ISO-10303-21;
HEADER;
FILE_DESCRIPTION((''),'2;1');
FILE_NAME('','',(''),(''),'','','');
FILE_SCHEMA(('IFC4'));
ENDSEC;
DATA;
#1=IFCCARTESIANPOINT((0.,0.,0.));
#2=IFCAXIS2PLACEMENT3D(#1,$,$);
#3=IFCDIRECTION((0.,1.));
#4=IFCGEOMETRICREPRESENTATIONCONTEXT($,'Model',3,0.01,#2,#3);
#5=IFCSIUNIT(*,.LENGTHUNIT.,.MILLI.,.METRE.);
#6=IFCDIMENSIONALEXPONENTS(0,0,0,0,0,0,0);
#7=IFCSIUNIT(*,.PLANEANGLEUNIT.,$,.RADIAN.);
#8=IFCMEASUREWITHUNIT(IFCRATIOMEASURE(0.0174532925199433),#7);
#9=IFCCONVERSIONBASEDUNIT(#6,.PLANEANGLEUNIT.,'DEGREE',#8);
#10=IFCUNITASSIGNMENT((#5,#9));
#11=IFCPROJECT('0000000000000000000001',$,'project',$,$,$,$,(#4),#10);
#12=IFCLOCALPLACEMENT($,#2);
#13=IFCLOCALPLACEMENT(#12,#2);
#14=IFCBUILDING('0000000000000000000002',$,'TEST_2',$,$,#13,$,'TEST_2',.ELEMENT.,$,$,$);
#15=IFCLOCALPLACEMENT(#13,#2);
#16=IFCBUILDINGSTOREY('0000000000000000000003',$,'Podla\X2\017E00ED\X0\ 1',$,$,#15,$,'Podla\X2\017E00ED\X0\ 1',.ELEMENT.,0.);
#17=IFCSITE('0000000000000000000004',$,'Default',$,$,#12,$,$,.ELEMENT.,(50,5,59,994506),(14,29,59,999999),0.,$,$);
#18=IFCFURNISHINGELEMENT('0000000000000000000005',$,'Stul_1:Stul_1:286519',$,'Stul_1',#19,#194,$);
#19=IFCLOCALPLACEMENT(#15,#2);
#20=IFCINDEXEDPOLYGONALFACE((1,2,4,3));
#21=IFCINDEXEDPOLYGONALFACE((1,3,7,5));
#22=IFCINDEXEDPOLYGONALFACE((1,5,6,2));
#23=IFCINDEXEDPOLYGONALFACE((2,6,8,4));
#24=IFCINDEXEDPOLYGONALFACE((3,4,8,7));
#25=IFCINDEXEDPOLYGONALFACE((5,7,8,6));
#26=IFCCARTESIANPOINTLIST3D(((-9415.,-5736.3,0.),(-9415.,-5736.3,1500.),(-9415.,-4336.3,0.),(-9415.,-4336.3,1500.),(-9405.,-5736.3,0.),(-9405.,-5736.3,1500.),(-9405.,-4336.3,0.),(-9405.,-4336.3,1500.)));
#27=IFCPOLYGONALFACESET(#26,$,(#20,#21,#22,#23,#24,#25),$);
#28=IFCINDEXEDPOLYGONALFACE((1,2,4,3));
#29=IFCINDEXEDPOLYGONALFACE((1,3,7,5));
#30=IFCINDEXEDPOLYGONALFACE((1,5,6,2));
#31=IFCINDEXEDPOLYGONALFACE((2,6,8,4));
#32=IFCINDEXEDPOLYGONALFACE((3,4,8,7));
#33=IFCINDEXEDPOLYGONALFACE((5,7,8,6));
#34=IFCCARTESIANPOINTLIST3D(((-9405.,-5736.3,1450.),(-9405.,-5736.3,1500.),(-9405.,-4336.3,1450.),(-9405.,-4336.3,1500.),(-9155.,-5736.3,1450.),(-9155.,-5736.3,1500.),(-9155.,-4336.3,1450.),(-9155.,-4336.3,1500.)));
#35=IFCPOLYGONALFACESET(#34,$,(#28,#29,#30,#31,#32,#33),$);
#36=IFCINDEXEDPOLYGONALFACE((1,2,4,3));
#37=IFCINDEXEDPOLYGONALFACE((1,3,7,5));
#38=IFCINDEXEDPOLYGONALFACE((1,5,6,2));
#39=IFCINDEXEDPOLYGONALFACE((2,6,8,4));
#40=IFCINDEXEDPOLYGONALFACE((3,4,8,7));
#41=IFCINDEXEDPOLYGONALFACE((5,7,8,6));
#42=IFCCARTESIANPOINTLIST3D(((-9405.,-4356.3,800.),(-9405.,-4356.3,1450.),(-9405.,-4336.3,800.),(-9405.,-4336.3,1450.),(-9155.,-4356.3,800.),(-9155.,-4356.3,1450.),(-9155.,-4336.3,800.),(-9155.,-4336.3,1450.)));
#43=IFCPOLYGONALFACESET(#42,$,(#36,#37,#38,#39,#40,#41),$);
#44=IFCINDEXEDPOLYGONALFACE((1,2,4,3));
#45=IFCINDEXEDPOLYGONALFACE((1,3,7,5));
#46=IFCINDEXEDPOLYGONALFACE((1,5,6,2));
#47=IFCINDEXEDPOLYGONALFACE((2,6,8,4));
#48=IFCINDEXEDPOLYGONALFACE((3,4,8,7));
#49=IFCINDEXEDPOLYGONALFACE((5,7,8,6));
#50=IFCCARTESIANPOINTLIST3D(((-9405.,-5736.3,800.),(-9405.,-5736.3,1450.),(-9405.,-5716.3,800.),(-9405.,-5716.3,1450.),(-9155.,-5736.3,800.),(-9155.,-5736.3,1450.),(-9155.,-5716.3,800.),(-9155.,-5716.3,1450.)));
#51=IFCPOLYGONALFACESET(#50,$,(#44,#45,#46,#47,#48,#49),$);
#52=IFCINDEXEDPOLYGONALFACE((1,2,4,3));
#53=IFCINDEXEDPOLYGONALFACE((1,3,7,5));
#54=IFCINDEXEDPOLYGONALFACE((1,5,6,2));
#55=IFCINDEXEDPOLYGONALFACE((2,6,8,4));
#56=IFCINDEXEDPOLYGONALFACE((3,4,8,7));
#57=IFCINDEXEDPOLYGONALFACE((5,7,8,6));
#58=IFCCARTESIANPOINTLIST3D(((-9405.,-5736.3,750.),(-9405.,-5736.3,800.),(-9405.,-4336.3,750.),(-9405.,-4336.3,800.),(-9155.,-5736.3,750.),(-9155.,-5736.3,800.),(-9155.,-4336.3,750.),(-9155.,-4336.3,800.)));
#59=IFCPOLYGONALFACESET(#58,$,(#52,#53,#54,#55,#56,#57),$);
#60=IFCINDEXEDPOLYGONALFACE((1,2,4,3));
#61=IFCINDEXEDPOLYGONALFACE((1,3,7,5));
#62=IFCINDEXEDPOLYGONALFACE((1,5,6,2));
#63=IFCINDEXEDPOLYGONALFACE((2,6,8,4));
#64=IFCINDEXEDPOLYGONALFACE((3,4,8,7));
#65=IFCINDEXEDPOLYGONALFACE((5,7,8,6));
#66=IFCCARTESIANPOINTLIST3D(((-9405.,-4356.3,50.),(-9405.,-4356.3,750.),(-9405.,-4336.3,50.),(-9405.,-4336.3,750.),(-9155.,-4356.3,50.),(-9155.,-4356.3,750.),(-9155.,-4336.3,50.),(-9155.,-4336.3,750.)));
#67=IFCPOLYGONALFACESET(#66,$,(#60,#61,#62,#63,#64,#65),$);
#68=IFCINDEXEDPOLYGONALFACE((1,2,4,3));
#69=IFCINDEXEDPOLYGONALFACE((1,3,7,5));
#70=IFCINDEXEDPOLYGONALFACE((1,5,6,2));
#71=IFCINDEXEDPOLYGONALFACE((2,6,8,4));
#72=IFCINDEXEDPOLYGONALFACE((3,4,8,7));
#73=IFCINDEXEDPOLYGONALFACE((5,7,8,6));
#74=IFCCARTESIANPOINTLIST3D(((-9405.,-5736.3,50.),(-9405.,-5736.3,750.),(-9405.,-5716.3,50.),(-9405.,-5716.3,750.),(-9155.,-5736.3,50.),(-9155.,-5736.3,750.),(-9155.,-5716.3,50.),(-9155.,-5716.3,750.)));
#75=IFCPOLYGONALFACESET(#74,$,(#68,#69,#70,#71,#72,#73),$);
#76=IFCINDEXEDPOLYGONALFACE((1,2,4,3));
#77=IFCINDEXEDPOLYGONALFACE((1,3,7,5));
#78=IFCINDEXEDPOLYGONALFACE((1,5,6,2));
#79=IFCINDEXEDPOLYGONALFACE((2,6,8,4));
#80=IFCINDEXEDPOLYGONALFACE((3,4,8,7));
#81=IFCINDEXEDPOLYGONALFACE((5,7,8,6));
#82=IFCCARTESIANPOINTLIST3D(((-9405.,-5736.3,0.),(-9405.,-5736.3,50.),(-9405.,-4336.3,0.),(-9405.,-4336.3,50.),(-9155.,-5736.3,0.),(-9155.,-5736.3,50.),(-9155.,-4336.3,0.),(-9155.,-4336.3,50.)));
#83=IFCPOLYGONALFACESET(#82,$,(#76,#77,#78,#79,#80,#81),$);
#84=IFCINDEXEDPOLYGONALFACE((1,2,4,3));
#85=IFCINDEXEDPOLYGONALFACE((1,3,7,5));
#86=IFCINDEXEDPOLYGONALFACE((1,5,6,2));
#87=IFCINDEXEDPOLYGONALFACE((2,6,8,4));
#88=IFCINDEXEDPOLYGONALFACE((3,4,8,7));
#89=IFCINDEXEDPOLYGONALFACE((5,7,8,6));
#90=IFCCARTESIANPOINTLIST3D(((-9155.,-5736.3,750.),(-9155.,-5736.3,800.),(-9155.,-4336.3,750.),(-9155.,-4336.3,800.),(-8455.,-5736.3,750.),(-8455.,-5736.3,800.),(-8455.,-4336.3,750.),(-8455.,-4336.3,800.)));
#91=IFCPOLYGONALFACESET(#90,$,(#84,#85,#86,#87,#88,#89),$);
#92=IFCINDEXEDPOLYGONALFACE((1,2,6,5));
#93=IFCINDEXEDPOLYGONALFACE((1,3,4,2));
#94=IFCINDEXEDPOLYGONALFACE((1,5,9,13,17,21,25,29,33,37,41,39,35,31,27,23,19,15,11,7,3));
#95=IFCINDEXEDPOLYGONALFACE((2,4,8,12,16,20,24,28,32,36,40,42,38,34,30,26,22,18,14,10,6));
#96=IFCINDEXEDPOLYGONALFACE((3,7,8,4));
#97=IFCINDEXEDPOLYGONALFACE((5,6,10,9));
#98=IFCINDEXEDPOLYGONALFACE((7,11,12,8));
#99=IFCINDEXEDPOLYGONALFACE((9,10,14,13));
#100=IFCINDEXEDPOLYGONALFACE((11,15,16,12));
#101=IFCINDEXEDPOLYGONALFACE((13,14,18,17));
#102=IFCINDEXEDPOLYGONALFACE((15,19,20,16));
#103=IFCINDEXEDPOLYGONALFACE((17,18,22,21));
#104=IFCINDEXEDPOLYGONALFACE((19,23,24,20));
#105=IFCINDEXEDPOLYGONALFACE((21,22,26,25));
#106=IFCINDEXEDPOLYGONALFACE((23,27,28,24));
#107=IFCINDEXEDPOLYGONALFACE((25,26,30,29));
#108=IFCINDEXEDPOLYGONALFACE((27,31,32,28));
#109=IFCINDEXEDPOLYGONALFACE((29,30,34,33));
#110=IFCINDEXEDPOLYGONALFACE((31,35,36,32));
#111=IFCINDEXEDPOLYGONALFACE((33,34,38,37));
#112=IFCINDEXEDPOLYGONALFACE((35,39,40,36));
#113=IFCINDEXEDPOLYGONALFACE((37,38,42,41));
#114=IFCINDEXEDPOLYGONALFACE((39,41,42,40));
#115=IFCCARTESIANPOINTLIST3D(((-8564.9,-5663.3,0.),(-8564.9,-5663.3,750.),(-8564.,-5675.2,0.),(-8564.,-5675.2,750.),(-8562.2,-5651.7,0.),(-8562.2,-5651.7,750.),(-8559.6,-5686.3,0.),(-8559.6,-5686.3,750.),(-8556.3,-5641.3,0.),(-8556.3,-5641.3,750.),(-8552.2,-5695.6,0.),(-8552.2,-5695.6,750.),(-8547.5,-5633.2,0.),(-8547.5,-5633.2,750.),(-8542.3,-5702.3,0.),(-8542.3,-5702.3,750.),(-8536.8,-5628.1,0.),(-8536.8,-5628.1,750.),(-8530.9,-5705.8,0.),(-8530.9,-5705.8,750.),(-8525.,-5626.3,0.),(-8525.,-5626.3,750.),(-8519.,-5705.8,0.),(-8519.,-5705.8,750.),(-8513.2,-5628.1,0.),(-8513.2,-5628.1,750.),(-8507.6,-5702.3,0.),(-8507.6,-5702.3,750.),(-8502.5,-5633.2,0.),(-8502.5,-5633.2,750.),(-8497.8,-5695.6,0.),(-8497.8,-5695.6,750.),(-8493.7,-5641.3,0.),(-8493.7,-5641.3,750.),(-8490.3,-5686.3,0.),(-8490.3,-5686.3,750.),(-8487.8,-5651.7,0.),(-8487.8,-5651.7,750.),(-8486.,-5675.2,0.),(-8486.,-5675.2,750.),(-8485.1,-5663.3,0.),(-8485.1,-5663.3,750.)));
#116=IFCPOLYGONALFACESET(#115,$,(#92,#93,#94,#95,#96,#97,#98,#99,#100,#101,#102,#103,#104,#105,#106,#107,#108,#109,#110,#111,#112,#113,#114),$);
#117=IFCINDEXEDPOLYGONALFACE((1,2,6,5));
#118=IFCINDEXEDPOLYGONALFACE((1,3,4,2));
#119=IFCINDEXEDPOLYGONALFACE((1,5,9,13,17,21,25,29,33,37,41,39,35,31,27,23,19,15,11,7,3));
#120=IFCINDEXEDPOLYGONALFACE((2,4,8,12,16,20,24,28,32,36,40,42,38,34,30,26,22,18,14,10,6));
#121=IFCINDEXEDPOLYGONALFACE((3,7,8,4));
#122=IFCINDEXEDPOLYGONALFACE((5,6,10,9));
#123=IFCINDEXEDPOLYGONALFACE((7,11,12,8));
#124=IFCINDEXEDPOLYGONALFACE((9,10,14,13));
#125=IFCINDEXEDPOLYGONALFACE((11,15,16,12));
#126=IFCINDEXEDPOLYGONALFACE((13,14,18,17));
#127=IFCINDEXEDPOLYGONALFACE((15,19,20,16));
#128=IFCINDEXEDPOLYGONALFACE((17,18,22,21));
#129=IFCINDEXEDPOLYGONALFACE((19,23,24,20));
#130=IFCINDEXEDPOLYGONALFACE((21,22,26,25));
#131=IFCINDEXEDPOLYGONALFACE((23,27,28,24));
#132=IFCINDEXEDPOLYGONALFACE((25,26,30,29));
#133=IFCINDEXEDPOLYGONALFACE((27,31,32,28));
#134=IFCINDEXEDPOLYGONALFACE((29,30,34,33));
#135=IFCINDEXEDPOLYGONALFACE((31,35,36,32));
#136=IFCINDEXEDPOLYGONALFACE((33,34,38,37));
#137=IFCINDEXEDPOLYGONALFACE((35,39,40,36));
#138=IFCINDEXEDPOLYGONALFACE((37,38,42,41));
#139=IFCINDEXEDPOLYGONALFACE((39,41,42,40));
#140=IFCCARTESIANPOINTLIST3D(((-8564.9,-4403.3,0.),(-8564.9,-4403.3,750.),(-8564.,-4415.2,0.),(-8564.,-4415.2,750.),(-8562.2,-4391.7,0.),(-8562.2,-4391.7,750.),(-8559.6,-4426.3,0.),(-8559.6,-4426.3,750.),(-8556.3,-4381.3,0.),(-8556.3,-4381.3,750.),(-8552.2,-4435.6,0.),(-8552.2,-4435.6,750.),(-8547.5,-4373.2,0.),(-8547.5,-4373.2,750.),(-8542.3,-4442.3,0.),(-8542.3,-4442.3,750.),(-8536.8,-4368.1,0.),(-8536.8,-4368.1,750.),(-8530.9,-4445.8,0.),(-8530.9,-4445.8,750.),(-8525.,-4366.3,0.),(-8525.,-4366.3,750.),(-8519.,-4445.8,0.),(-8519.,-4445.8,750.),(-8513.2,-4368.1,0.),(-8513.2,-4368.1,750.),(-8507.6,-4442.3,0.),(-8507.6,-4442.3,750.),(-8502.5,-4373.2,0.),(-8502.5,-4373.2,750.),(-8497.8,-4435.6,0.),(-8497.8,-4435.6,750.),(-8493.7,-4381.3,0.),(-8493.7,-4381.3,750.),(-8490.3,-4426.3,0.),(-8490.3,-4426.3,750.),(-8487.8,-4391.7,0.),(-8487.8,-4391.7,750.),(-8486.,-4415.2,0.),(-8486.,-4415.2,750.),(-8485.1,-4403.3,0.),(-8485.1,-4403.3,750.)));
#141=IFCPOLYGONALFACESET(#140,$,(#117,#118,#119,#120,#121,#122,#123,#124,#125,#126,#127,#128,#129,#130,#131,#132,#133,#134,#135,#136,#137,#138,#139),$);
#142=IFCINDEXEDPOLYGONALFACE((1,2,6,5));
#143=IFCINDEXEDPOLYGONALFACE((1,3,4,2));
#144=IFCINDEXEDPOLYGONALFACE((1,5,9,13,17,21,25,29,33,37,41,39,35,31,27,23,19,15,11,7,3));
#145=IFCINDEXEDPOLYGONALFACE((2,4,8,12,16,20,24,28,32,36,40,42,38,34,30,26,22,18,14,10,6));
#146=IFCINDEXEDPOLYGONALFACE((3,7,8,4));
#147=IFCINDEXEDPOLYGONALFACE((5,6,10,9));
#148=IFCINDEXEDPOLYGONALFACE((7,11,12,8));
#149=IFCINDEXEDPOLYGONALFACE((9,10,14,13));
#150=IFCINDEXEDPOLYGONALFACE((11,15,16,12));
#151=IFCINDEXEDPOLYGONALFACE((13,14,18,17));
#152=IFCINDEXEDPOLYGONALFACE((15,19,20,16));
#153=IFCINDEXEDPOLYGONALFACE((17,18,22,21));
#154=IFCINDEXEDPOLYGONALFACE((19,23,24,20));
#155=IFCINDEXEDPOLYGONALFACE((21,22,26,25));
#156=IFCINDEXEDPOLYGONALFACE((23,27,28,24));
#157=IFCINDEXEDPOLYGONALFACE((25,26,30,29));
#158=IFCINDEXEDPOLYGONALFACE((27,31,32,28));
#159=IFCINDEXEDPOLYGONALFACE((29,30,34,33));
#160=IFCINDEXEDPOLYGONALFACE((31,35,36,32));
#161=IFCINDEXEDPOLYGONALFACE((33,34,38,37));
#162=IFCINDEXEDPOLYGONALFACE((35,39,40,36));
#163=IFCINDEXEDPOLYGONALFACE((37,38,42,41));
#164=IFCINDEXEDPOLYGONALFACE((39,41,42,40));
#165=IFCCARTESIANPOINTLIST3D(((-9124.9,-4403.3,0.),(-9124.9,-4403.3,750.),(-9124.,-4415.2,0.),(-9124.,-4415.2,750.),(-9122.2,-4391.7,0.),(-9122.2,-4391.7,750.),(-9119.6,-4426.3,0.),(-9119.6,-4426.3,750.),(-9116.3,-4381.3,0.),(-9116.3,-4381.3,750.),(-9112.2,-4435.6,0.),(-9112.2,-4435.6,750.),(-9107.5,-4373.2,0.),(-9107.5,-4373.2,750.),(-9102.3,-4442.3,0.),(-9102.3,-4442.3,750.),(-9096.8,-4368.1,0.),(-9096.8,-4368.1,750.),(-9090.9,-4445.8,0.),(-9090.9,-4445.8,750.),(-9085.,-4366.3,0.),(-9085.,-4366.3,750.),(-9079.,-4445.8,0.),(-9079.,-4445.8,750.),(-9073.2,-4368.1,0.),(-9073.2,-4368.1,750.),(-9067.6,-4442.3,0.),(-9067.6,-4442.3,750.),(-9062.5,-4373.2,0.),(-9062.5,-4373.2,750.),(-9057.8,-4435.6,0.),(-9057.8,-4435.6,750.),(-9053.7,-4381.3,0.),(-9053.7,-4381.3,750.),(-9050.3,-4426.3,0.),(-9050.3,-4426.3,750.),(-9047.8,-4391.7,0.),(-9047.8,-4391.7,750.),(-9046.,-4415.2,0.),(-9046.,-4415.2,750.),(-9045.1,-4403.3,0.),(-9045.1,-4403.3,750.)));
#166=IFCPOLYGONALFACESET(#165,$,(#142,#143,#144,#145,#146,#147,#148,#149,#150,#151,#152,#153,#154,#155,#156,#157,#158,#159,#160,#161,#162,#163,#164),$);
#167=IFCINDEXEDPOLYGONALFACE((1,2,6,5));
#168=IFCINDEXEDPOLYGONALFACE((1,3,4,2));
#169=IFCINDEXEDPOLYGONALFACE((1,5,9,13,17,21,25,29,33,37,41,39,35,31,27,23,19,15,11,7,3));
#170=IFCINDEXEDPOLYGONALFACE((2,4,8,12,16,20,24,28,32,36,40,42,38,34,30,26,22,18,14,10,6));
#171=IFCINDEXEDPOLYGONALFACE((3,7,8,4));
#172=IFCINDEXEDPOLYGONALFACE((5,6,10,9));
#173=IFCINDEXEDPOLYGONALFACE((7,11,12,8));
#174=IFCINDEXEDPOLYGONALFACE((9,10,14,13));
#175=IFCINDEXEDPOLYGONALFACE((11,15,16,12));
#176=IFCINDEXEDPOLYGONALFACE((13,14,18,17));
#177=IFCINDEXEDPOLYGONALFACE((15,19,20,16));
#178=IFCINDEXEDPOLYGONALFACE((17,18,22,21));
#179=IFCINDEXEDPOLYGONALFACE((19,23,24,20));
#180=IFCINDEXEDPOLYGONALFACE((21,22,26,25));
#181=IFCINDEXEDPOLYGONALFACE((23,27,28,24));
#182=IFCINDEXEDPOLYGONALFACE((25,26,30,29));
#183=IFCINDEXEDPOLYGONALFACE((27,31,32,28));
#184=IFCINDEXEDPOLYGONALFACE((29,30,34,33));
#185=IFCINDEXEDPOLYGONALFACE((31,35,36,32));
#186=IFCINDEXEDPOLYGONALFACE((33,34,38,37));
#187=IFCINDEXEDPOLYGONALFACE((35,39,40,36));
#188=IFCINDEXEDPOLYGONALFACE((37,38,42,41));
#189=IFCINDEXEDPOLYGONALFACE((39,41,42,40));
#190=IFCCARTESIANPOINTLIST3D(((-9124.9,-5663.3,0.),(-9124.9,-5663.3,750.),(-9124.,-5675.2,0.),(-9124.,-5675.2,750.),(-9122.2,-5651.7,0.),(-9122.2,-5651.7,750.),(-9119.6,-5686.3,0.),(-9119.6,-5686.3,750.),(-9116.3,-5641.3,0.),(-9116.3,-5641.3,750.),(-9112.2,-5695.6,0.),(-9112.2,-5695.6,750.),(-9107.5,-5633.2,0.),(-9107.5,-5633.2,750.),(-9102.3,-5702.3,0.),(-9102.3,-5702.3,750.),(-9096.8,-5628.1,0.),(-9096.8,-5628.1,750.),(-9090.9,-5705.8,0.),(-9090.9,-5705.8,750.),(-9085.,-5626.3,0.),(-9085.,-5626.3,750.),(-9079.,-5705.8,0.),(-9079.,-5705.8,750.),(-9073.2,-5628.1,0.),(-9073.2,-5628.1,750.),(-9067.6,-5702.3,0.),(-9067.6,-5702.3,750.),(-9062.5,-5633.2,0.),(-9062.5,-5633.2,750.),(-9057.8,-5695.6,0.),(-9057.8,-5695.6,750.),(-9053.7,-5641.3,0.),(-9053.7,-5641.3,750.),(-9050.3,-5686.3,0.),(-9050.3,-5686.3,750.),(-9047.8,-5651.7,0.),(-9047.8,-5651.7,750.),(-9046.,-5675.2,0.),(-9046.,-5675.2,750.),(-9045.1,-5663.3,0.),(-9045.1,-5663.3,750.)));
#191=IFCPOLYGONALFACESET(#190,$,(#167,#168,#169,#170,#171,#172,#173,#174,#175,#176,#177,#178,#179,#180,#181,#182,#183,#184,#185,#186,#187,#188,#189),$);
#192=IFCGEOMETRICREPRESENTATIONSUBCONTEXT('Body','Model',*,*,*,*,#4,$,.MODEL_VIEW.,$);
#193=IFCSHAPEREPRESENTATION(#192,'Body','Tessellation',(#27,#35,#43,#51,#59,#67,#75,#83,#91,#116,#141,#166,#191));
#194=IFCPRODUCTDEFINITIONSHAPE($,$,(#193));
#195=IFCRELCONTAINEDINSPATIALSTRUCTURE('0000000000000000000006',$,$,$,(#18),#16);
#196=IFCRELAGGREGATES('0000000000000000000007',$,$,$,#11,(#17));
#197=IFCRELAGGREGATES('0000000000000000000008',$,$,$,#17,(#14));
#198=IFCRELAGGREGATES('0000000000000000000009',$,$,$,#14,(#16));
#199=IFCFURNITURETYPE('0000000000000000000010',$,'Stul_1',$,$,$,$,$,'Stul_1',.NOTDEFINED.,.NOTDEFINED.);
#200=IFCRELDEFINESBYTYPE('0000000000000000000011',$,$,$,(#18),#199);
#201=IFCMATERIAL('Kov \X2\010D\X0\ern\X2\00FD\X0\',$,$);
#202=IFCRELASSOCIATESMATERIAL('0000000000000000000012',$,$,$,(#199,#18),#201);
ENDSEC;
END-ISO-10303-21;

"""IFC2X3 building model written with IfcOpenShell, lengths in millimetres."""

from ifc_helpers import new_model, entity, si_unit, converted_unit, direction, frame, frame_2d, origin, origin_2d_with_axis, place, context, subcontext, project, spatial, rectangle, circle, extrude, source, transform, mapped, material, type_object, type_shapes, element, save


model = new_model("IFC2X3")

# Units and contexts
model_context = context("Model", 3, precision=0.01, world=origin(), true_north=direction((0.0, 1.0)))
body_context = subcontext(model_context, "Body", "Model", "MODEL_VIEW")
ifc_project = project(units=[si_unit("LENGTHUNIT", "METRE", prefix="MILLI"), converted_unit("PLANEANGLEUNIT", "DEGREE", entity("IfcRatioMeasure", 0.0174532925199433), si_unit("PLANEANGLEUNIT", "RADIAN"), dimensions=[0, 0, 0, 0, 0, 0, 0])], contexts=[model_context])

# Site, building, storey
site_placement = place(None, origin())
site = spatial("IfcSite", under=ifc_project, at=site_placement, Name="Default", CompositionType="ELEMENT", RefLatitude=(50, 5, 59, 994506), RefLongitude=(14, 29, 59, 999999), RefElevation=0.0)
building_placement = place(site_placement, origin())
building = spatial("IfcBuilding", under=site, at=building_placement, Name="TEST_2", LongName="TEST_2", CompositionType="ELEMENT")
storey_placement = place(building_placement, origin())
storey = spatial("IfcBuildingStorey", under=building, at=storey_placement, Name="Podlaží 1", LongName="Podlaží 1", CompositionType="ELEMENT", Elevation=0.0)

# Furnishing element
ifc_material_1 = material(Name="Kov černý")
furniture_type = type_object("IfcFurnitureType", Name="Stul_1", ElementType="Stul_1", material=ifc_material_1)
shared_shape_1 = source(origin(), body_context, "Body", "SweptSolid", [
    extrude(rectangle(XDim=1400.0, YDim=10.0, at=origin_2d_with_axis()), frame((0.0, 605.0, 0.0), z_axis=(0.0, 0.0, 1.0), x_axis=(-1.0, 0.0, 0.0)), (0.0, 0.0, 1.0), 1500.0),
    extrude(rectangle(XDim=1400.0, YDim=250.0, at=frame_2d((0.0, 0.0), x_axis=(1.0, 0.0))), frame((0.0, 475.0, 1450.0), z_axis=(0.0, 0.0, 1.0), x_axis=(-1.0, 0.0, 0.0)), (0.0, 0.0, 1.0), 50.0),
    extrude(rectangle(XDim=20.0, YDim=250.0, at=origin_2d_with_axis()), frame((690.0, 475.0, 800.0), z_axis=(0.0, 0.0, 1.0), x_axis=(-1.0, 0.0, 0.0)), (0.0, 0.0, 1.0), 650.0),
    extrude(rectangle(XDim=20.0, YDim=250.0, at=frame_2d((0.0, 0.0), x_axis=(1.0, 0.0))), frame((-690.0, 475.0, 800.0), z_axis=(0.0, 0.0, 1.0), x_axis=(-1.0, 0.0, 0.0)), (0.0, 0.0, 1.0), 650.0),
    extrude(rectangle(XDim=1400.0, YDim=250.0, at=origin_2d_with_axis()), frame((0.0, 475.0, 750.0), z_axis=(0.0, 0.0, 1.0), x_axis=(-1.0, 0.0, 0.0)), (0.0, 0.0, 1.0), 50.0),
    extrude(rectangle(XDim=20.0, YDim=250.0, at=origin_2d_with_axis()), frame((690.0, 475.0, 50.0), z_axis=(0.0, 0.0, 1.0), x_axis=(-1.0, 0.0, 0.0)), (0.0, 0.0, 1.0), 700.0),
    extrude(rectangle(XDim=20.0, YDim=250.0, at=frame_2d((0.0, 0.0), x_axis=(1.0, 0.0))), frame((-690.0, 475.0, 50.0), z_axis=(0.0, 0.0, 1.0), x_axis=(-1.0, 0.0, 0.0)), (0.0, 0.0, 1.0), 700.0),
    extrude(rectangle(XDim=1400.0, YDim=250.0, at=origin_2d_with_axis()), frame((0.0, 475.0, 0.0), z_axis=(0.0, 0.0, 1.0), x_axis=(-1.0, 0.0, 0.0)), (0.0, 0.0, 1.0), 50.0),
    extrude(rectangle(XDim=1400.0, YDim=700.0, at=origin_2d_with_axis()), frame((0.0, 0.0, 750.0), z_axis=(0.0, 0.0, 1.0), x_axis=(-1.0, 0.0, 0.0)), (0.0, 0.0, 1.0), 50.0),
    extrude(circle(Radius=40.0, at=frame_2d((0.0, 0.0), x_axis=(1.0, 0.0))), frame((-630.0, -280.0, 0.0)), (0.0, 0.0, 1.0), 750.0),
    extrude(circle(Radius=40.0, at=frame_2d((0.0, 0.0), x_axis=(1.0, 0.0))), frame((630.0, -280.0, 0.0)), (0.0, 0.0, 1.0), 750.0),
    extrude(circle(Radius=40.0, at=frame_2d((0.0, 0.0), x_axis=(1.0, 0.0))), frame((630.0, 280.0, 0.0)), (0.0, 0.0, 1.0), 750.0),
    extrude(circle(Radius=40.0, at=frame_2d((0.0, 0.0), x_axis=(1.0, 0.0))), frame((-630.0, 280.0, 0.0)), (0.0, 0.0, 1.0), 750.0),
])
type_shapes(furniture_type, [shared_shape_1])
for number, where, z_axis, x_axis, name in (
    (1, (-8805.0, -5036.3, 0.0), (0.0, 0.0, 1.0), (0.0, 1.0, 0.0), "Stul_1:Stul_1:286519"),
):
    element("IfcFurnishingElement", number, at=place(storey_placement, frame(where, z_axis=z_axis, x_axis=x_axis)), inside=storey, type_object=furniture_type, material=ifc_material_1, Name=name, ObjectType="Stul_1", context=body_context, shape_type="MappedRepresentation", body=[
        mapped(shared_shape_1, transform((0.0, 0.0, 0.0), scale=1.0)),
    ])

save(model, "model.ifc")
